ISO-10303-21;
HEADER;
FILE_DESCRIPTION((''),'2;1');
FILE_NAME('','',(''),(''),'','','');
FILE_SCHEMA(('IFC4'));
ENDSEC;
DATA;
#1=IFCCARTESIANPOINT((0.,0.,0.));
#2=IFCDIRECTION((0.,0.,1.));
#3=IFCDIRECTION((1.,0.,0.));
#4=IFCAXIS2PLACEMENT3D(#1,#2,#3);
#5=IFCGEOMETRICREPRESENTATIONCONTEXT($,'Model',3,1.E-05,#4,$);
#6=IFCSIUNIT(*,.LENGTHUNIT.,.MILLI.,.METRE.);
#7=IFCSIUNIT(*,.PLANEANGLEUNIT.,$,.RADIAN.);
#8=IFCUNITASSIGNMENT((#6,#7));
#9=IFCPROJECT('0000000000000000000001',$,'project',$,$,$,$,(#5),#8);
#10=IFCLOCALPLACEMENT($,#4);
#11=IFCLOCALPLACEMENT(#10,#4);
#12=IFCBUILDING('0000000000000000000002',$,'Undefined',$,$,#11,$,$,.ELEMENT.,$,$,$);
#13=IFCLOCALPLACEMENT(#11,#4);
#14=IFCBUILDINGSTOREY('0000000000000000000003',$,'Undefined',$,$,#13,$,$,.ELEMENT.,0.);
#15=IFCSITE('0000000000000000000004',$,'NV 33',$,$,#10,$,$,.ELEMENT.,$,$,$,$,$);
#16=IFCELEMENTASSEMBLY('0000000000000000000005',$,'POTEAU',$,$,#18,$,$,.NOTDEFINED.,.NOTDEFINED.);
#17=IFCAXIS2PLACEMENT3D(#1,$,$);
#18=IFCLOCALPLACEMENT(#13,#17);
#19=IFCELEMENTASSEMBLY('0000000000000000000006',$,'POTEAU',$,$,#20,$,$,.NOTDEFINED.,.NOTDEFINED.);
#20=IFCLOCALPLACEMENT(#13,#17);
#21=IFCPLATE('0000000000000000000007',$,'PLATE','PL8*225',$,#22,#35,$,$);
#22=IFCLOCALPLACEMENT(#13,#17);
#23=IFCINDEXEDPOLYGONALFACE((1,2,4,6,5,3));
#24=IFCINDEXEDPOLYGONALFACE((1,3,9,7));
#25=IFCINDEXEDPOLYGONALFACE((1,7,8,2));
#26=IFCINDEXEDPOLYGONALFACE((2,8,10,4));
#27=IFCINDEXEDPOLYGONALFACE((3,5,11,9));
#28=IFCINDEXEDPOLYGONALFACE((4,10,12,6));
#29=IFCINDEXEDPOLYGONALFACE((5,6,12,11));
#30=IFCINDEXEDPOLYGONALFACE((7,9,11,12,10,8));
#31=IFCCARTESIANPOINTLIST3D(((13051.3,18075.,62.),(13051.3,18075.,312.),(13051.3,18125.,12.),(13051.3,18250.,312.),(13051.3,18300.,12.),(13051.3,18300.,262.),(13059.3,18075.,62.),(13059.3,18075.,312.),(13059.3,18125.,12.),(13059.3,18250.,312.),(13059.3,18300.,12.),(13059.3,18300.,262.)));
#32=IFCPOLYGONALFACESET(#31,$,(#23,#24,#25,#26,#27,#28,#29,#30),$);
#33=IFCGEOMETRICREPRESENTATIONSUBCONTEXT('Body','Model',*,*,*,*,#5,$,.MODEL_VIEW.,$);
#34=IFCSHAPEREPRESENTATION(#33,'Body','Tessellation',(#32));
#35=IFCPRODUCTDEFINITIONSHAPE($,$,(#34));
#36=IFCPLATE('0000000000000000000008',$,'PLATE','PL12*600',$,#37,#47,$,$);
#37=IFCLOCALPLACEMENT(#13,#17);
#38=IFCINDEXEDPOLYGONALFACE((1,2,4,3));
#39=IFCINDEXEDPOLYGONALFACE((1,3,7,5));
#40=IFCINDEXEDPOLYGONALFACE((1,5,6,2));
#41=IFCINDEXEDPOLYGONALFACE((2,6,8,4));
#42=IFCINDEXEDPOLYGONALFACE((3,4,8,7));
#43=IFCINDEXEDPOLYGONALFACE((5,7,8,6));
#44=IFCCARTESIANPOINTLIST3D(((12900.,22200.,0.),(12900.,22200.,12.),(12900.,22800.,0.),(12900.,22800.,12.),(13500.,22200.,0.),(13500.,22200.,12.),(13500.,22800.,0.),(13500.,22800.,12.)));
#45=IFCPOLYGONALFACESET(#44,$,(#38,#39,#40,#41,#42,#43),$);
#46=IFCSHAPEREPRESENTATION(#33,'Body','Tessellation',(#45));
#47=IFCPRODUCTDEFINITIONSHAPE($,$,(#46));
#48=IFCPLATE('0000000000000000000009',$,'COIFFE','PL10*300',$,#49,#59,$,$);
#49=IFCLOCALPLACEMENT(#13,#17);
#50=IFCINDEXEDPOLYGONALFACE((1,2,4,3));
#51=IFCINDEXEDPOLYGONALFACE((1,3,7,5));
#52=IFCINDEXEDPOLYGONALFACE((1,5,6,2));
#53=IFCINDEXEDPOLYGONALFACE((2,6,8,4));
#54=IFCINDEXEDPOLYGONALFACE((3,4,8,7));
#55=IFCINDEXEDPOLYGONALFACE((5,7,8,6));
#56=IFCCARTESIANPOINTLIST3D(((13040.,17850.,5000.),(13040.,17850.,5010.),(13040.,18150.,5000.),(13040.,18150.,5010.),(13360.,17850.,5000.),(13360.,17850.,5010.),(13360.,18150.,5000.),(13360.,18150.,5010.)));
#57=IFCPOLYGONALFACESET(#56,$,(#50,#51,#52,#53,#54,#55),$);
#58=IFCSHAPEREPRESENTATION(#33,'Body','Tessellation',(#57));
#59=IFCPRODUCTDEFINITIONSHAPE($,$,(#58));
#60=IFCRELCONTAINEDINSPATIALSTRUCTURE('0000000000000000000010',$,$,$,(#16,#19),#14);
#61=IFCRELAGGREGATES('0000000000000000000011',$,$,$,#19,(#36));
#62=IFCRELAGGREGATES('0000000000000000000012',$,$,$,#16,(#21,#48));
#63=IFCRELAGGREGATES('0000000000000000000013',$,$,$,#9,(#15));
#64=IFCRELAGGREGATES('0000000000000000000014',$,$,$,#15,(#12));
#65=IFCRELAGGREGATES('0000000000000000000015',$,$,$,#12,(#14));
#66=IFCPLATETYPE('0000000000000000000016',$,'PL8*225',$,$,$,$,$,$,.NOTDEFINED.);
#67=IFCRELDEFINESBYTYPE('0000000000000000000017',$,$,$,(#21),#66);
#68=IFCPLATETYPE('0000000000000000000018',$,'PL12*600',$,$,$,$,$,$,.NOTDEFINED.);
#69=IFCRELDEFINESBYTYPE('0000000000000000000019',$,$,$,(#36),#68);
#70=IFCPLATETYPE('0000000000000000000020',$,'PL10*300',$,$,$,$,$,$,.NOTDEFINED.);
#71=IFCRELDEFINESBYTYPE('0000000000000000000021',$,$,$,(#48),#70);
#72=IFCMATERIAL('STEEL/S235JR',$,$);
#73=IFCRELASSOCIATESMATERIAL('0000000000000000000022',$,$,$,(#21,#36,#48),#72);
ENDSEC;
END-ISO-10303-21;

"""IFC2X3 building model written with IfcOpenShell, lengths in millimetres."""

from ifc_helpers import new_model, si_unit, frame, origin_with_axes, place, context, subcontext, project, spatial, polyline, outline, extrude, material, type_object, element, aggregate, save


model = new_model("IFC2X3")

# Units and contexts
model_context = context("Model", 3, precision=1e-05, world=origin_with_axes())
body_context = subcontext(model_context, "Body", "Model", "MODEL_VIEW")
ifc_project = project(units=[si_unit("LENGTHUNIT", "METRE", prefix="MILLI"), si_unit("PLANEANGLEUNIT", "RADIAN")], contexts=[model_context])

# Site, building, storey
site_placement = place(None, origin_with_axes())
site = spatial("IfcSite", under=ifc_project, at=site_placement, Name="NV 33", CompositionType="ELEMENT")
building_placement = place(site_placement, origin_with_axes())
building = spatial("IfcBuilding", under=site, at=building_placement, Name="Undefined", CompositionType="ELEMENT")
storey_placement = place(building_placement, origin_with_axes())
storey = spatial("IfcBuildingStorey", under=building, at=storey_placement, Name="Undefined", CompositionType="ELEMENT", Elevation=0.0)

# Element assembly
assembly_1_placement = place(storey_placement, origin_with_axes())
assembly_1 = element("IfcElementAssembly", 1, at=assembly_1_placement, inside=storey, Name="POTEAU", AssemblyPlace="NOTDEFINED", PredefinedType="NOTDEFINED")
ifc_material_1 = material(Name="STEEL/S235JR")

# Element assembly
assembly_2_placement = place(storey_placement, origin_with_axes())
assembly_2 = element("IfcElementAssembly", 2, at=assembly_2_placement, inside=storey, Name="POTEAU", AssemblyPlace="NOTDEFINED", PredefinedType="NOTDEFINED")

# Plates
plate_type_1 = type_object("IfcPlateType", Name="PL8*225", PredefinedType="NOTDEFINED")
plate_1_placement = place(assembly_1_placement, frame((13055.3, 18075.0, 12.0), z_axis=(1.0, 0.0, 0.0), x_axis=(0.0, 1.0, 0.0)))
plate_1 = element("IfcPlate", 3, at=plate_1_placement, type_object=plate_type_1, material=ifc_material_1, Name="PLATE", Description="PL8*225", context=body_context, shape_type="SweptSolid", body=[
    extrude(outline(polyline([(0.0, 50.0), (50.0, 0.0), (225.0, 0.0), (225.0, 250.0), (175.0, 300.0), (0.0, 300.0), (0.0, 50.0)])), frame((0.0, 0.0, -4.0), z_axis=(0.0, 0.0, 1.0), x_axis=(1.0, 0.0, 0.0)), (0.0, 0.0, 1.0), 8.0),
])
plate_type_2 = type_object("IfcPlateType", Name="PL12*600", PredefinedType="NOTDEFINED")
plate_2_placement = place(assembly_2_placement, frame((12900.0, 22200.0, 6.0), z_axis=(0.0, 0.0, 1.0), x_axis=(1.0, 0.0, 0.0)))
plate_2 = element("IfcPlate", 4, at=plate_2_placement, type_object=plate_type_2, material=ifc_material_1, Name="PLATE", Description="PL12*600", context=body_context, shape_type="SweptSolid", body=[
    extrude(outline(polyline([(0.0, 0.0), (600.0, 0.0), (600.0, 600.0), (0.0, 600.0), (0.0, 0.0)])), frame((0.0, 0.0, -6.0), z_axis=(0.0, 0.0, 1.0), x_axis=(1.0, 0.0, 0.0)), (0.0, 0.0, 1.0), 12.0),
])
aggregate(assembly_2, [plate_2])
plate_type_3 = type_object("IfcPlateType", Name="PL10*300", PredefinedType="NOTDEFINED")
plate_3_placement = place(assembly_1_placement, frame((13040.0, 18150.0, 5005.0), z_axis=(0.0, 0.0, 1.0), x_axis=(0.0, -1.0, 0.0)))
plate_3 = element("IfcPlate", 5, at=plate_3_placement, type_object=plate_type_3, material=ifc_material_1, Name="COIFFE", Description="PL10*300", context=body_context, shape_type="SweptSolid", body=[
    extrude(outline(polyline([(0.0, 0.0), (300.0, 0.0), (300.0, 320.0), (0.0, 320.0), (0.0, 0.0)])), frame((0.0, 0.0, -5.0), z_axis=(0.0, 0.0, 1.0), x_axis=(1.0, 0.0, 0.0)), (0.0, 0.0, 1.0), 10.0),
])

aggregate(assembly_1, [plate_1, plate_3])

save(model, "model.ifc")
